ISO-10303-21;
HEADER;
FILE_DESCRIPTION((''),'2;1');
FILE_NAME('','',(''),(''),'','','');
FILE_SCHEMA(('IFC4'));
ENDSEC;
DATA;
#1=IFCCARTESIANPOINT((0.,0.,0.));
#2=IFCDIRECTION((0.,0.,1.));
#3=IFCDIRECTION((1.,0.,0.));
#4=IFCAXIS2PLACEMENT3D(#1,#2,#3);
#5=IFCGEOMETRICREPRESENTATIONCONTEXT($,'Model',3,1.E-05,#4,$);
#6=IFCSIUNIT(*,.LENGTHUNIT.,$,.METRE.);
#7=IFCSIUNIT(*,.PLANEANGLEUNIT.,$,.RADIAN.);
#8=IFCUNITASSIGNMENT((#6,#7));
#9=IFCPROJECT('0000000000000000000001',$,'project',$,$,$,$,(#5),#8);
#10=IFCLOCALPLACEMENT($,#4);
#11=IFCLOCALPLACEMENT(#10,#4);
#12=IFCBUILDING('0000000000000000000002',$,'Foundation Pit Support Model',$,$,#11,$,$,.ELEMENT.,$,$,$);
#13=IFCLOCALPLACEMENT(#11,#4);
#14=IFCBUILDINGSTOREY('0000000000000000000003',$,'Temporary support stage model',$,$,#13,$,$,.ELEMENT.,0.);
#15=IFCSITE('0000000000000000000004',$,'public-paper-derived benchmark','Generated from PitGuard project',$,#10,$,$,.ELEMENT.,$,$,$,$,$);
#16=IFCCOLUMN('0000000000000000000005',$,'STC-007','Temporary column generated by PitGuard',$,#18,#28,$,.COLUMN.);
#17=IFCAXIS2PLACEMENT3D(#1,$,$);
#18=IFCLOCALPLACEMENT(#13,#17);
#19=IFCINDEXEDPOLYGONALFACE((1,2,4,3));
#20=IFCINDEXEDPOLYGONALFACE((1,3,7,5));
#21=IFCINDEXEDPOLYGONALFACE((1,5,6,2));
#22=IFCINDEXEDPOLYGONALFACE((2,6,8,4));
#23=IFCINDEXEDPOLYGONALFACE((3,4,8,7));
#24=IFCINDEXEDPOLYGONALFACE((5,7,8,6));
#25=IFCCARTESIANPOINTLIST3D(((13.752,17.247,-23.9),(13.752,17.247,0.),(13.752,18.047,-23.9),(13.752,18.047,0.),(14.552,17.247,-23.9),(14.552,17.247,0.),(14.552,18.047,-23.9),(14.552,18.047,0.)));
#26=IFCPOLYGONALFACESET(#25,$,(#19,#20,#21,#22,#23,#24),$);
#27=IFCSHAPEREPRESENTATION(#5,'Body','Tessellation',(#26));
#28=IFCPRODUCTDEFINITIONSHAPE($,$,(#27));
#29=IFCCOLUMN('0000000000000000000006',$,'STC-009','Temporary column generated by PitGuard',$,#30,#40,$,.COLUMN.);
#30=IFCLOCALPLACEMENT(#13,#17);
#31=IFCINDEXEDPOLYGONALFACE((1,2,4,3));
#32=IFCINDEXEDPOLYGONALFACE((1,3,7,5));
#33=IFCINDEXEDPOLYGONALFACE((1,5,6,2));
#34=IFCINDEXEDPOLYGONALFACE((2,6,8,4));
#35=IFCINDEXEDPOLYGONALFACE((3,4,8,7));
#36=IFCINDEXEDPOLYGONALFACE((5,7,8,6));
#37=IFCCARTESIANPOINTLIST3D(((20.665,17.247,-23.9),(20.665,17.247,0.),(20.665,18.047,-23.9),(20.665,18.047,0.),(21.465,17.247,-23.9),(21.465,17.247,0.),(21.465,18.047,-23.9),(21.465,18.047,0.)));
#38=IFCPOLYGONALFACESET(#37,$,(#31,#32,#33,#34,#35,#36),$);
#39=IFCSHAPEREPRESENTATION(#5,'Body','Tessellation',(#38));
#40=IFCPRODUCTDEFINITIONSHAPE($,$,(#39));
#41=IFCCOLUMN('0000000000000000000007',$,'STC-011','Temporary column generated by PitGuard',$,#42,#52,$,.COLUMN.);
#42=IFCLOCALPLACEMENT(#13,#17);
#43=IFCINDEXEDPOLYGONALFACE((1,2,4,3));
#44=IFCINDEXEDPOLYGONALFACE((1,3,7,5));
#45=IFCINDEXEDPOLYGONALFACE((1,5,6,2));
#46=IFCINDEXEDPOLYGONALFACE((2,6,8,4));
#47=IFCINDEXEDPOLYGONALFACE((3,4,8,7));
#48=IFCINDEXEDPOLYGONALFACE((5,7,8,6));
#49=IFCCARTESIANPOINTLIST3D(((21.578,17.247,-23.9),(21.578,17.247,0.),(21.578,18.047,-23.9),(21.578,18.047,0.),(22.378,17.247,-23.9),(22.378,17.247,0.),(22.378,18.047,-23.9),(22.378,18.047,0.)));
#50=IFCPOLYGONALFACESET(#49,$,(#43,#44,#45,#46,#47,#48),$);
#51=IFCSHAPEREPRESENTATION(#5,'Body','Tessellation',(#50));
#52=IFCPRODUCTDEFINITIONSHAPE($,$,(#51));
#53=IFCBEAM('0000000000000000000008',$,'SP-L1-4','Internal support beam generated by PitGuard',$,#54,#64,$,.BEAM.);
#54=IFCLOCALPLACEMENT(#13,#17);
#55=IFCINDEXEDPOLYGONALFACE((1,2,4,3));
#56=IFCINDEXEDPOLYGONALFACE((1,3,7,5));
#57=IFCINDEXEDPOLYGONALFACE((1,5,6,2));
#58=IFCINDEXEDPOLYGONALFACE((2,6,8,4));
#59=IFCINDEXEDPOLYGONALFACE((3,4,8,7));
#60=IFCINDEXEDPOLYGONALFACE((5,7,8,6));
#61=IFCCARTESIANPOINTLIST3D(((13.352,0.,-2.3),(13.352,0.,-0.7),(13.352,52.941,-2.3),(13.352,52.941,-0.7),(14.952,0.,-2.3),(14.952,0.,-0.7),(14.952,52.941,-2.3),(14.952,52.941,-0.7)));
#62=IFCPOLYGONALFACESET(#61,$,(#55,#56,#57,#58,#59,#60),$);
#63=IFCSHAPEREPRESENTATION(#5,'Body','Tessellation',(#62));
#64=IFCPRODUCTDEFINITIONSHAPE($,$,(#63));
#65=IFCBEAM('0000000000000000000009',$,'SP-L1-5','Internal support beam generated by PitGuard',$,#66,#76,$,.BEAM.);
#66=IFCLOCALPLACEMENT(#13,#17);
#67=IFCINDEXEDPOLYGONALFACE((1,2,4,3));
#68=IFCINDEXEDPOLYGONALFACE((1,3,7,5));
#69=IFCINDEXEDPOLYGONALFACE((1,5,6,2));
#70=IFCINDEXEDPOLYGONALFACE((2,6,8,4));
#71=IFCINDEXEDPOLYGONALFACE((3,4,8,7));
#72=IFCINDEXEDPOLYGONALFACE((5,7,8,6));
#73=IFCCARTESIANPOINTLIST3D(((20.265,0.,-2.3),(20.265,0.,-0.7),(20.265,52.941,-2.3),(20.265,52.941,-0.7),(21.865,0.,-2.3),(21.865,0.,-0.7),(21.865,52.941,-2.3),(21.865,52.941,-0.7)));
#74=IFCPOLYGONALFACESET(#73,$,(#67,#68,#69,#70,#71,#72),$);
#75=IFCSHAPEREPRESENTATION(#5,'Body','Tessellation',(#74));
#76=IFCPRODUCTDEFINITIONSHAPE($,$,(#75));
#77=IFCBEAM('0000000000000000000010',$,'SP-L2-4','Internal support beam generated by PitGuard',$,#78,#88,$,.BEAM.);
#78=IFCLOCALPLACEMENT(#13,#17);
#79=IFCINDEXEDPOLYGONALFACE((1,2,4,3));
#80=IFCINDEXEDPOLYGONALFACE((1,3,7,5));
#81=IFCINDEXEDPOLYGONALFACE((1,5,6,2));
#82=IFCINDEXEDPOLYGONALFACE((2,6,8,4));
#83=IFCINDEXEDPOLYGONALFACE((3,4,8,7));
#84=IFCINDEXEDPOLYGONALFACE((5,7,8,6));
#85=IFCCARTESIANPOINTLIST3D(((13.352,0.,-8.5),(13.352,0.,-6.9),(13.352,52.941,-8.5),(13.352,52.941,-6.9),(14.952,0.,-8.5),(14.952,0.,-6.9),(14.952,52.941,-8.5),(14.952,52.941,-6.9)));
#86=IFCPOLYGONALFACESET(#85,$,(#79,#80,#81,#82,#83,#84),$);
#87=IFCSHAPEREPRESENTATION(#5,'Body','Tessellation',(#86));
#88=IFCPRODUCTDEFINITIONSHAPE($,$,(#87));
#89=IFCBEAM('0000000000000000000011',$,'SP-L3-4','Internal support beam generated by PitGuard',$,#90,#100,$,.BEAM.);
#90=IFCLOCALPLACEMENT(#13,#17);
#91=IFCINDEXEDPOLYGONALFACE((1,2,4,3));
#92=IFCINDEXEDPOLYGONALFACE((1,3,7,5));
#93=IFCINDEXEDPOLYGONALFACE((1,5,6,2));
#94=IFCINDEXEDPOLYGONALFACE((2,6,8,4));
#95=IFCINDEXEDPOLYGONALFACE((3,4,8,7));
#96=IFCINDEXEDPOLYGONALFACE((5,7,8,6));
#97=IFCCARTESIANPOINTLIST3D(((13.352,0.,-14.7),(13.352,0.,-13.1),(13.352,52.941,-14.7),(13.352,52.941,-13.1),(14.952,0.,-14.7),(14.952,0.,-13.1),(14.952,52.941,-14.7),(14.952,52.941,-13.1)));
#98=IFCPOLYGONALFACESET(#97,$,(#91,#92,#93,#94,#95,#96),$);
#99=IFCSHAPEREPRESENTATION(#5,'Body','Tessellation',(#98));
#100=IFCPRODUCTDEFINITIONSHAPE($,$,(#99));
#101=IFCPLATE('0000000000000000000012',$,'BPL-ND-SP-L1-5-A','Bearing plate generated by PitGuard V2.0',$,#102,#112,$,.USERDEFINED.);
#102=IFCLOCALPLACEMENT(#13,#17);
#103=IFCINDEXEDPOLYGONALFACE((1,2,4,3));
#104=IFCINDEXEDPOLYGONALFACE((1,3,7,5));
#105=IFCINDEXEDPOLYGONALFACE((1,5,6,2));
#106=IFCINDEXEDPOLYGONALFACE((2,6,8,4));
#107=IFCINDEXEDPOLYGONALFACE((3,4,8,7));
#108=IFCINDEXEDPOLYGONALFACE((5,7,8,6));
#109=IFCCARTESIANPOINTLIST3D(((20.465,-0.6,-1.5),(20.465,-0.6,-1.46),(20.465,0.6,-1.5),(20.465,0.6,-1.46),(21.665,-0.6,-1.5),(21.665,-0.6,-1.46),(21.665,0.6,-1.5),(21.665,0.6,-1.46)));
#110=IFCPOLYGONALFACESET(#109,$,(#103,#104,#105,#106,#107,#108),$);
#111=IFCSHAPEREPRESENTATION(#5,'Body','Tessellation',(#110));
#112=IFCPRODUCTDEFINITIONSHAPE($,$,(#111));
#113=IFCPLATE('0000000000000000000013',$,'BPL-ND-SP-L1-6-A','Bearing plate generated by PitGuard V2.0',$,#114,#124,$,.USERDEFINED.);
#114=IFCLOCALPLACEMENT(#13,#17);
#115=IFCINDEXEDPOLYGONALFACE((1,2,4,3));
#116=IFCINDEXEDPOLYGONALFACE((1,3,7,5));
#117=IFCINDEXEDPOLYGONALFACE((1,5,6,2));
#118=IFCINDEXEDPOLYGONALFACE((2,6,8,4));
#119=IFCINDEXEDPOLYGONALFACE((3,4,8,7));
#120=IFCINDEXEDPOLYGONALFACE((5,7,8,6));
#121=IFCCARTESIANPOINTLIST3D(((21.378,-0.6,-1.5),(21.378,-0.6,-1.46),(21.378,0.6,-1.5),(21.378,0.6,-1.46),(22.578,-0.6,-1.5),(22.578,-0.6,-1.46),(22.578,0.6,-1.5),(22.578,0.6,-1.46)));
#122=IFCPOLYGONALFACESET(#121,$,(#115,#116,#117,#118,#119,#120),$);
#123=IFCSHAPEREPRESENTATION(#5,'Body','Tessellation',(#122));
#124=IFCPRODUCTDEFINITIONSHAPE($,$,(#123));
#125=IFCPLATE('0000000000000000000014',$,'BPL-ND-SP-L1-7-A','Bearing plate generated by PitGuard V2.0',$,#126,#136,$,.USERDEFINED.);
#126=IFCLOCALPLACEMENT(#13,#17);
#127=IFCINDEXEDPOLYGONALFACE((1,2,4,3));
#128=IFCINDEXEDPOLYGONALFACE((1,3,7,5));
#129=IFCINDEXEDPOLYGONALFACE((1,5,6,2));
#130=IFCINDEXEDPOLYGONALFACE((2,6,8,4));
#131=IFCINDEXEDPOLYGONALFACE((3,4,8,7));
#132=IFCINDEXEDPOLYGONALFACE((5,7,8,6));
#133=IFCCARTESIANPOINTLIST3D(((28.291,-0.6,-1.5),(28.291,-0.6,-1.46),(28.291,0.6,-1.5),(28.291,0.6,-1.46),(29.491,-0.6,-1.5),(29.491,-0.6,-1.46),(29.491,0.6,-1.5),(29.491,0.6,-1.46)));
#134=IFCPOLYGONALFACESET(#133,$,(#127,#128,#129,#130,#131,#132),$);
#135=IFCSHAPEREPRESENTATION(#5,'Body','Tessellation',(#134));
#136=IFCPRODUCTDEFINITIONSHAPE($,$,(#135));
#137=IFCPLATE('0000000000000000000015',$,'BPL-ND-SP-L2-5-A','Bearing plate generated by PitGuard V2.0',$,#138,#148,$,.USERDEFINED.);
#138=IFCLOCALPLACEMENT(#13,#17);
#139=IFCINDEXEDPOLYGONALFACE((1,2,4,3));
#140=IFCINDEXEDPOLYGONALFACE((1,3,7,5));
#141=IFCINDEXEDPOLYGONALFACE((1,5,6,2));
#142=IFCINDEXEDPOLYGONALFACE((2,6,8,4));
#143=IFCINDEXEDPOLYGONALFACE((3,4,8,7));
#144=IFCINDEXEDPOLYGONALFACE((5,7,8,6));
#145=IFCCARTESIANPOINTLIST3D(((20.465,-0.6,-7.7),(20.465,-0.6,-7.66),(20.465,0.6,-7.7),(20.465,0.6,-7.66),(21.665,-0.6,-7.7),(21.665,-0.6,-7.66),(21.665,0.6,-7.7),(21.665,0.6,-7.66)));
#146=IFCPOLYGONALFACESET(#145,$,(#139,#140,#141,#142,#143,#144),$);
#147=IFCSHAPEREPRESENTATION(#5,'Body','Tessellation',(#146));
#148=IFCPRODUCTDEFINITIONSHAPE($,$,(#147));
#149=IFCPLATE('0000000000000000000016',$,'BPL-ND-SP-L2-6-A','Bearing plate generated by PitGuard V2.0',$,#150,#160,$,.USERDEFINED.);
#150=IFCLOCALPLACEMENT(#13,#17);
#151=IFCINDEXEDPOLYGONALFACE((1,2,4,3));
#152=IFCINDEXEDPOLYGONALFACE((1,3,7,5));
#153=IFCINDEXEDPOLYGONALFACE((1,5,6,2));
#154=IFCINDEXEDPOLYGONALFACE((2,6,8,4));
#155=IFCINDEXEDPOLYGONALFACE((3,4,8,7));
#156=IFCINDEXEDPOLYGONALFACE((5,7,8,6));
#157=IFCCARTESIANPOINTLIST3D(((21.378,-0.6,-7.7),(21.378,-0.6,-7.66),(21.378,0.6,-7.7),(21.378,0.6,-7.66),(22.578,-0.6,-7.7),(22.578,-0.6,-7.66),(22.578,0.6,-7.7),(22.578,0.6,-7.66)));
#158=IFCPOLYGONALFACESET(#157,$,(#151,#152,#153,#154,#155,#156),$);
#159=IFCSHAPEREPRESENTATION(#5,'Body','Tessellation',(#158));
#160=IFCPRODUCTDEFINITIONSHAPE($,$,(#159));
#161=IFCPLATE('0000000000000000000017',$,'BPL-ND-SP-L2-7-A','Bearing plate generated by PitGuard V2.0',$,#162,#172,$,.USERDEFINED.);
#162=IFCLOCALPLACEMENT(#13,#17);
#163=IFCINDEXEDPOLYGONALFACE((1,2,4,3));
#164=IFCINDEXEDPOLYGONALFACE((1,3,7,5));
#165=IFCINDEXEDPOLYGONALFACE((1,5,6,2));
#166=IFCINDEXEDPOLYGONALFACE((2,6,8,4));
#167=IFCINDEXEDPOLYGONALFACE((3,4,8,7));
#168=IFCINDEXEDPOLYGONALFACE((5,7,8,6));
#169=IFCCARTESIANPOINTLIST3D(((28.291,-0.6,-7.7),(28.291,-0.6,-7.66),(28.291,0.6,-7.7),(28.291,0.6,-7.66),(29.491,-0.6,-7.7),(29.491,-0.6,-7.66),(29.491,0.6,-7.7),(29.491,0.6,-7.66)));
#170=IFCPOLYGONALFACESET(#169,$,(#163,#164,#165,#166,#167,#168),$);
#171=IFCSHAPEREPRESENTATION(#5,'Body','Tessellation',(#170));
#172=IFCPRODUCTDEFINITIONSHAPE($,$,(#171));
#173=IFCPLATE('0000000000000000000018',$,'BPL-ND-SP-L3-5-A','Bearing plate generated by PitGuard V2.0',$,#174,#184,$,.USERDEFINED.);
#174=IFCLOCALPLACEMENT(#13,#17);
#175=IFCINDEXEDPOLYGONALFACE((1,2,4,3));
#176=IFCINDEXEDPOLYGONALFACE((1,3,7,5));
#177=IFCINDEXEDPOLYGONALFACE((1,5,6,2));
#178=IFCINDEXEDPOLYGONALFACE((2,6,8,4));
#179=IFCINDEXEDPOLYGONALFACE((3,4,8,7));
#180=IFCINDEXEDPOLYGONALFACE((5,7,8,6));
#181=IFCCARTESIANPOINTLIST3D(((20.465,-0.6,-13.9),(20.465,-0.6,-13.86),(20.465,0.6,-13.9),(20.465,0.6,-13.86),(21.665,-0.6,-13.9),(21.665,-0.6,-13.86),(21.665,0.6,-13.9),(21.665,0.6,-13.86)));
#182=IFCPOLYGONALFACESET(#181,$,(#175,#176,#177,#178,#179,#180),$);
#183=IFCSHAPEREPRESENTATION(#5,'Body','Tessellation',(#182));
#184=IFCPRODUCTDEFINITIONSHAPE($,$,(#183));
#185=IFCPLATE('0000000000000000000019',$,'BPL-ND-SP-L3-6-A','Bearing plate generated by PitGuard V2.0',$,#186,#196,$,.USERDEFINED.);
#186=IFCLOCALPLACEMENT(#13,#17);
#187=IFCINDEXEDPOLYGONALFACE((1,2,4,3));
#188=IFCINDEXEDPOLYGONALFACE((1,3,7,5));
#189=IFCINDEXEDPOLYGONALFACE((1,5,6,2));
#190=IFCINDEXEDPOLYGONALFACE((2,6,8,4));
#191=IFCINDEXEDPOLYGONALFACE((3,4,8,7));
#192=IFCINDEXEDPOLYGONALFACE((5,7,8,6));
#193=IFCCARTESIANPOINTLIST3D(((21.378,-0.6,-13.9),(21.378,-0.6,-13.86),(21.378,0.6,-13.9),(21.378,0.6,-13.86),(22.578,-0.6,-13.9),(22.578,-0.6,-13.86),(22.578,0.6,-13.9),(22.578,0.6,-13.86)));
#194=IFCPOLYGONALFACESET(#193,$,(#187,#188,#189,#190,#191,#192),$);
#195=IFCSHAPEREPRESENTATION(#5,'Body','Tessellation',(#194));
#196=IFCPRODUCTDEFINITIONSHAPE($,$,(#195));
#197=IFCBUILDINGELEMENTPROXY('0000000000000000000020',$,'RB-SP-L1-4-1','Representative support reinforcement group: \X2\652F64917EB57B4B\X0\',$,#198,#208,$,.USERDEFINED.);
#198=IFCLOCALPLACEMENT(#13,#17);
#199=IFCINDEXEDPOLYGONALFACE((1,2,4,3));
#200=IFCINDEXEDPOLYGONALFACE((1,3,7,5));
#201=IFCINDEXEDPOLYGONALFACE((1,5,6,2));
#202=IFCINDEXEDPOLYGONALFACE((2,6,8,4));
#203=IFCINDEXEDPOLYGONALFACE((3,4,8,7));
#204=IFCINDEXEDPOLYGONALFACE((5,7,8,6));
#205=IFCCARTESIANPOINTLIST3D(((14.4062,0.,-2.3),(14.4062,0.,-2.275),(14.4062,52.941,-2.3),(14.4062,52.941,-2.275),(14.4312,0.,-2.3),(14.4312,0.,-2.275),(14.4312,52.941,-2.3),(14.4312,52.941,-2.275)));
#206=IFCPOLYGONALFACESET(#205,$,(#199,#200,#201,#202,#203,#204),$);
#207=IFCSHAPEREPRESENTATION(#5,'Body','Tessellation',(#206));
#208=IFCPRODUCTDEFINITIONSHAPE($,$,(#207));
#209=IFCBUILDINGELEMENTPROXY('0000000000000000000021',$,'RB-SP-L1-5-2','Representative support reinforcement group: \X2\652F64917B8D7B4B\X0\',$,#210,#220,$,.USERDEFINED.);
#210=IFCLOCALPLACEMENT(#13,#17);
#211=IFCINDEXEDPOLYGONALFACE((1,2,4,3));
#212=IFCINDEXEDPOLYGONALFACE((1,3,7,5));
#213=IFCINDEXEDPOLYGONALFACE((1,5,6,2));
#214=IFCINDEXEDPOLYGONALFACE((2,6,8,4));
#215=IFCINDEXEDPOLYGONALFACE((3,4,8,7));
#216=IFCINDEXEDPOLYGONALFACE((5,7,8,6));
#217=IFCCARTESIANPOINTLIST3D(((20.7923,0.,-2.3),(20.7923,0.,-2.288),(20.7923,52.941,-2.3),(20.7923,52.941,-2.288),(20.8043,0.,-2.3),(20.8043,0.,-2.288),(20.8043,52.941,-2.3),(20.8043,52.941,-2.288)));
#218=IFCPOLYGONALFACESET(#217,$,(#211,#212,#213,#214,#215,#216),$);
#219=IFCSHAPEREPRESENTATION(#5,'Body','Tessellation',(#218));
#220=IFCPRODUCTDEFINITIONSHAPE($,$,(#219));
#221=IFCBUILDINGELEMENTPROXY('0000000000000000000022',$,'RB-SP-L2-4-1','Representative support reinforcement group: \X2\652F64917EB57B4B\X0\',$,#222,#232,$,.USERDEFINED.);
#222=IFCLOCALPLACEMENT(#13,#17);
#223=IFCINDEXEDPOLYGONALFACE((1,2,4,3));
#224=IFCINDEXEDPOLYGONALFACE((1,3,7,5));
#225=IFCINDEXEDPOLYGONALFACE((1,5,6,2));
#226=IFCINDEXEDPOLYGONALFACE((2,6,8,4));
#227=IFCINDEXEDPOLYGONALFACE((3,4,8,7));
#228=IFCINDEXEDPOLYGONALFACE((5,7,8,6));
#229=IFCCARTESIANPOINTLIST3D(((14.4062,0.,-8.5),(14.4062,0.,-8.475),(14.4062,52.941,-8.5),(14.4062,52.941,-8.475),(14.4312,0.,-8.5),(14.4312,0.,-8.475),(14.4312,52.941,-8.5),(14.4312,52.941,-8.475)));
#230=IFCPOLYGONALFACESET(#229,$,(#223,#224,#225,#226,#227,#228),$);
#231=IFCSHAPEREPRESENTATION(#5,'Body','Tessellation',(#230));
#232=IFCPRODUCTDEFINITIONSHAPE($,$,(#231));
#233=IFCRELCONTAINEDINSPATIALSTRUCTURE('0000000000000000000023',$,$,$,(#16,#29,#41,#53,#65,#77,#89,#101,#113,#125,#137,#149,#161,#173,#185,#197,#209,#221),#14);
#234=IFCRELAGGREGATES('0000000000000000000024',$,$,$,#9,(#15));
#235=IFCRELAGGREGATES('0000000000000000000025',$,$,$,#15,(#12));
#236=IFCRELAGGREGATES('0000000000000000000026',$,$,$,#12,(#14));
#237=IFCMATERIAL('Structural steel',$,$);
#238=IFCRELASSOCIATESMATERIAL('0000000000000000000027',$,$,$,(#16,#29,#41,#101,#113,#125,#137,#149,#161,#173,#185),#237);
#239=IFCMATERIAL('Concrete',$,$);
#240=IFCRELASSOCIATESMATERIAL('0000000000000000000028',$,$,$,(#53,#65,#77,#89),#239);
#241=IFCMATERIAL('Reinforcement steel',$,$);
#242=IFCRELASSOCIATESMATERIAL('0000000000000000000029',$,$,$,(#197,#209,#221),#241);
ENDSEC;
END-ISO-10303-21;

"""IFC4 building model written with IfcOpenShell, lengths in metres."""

from ifc_helpers import new_model, si_unit, frame, origin_with_axes, origin_2d, place, context, project, spatial, rectangle, extrude, material, element, save


model = new_model("IFC4")

# Units and contexts
model_context = context("Model", 3, precision=1e-05, world=origin_with_axes())
ifc_project = project(units=[si_unit("LENGTHUNIT", "METRE"), si_unit("PLANEANGLEUNIT", "RADIAN")], contexts=[model_context])

# Site, building, storey
site_placement = place(None, origin_with_axes())
site = spatial("IfcSite", under=ifc_project, at=site_placement, Name="public-paper-derived benchmark", Description="Generated from PitGuard project", CompositionType="ELEMENT")
building_placement = place(site_placement, origin_with_axes())
building = spatial("IfcBuilding", under=site, at=building_placement, Name="Foundation Pit Support Model", CompositionType="ELEMENT")
storey_placement = place(building_placement, origin_with_axes())
storey = spatial("IfcBuildingStorey", under=building, at=storey_placement, Name="Temporary support stage model", CompositionType="ELEMENT", Elevation=0.0)

# Columns
ifc_material_1 = material(Name="Structural steel")
for number, where, z_axis, x_axis, name in (
    (1, (14.152, 17.647, -23.9), (0.0, 0.0, 1.0), (1.0, 0.0, 0.0), "STC-007"),
    (2, (21.065, 17.647, -23.9), (0.0, 0.0, 1.0), (1.0, 0.0, 0.0), "STC-009"),
    (3, (21.978, 17.647, -23.9), (0.0, 0.0, 1.0), (1.0, 0.0, 0.0), "STC-011"),
):
    element("IfcColumn", number, at=place(storey_placement, frame(where, z_axis=z_axis, x_axis=x_axis)), inside=storey, material=ifc_material_1, Name=name, Description="Temporary column generated by PitGuard", PredefinedType="COLUMN", context=model_context, shape_type="SweptSolid", body=[
        extrude(rectangle(XDim=0.8, YDim=0.8, at=origin_2d()), origin_with_axes(), (0.0, 0.0, 1.0), 23.9),
    ])

# Beams
ifc_material_2 = material(Name="Concrete")
for number, where, z_axis, x_axis, name in (
    (4, (14.152, 26.4705, -2.3), (0.0, 0.0, 1.0), (0.0, 1.0, 0.0), "SP-L1-4"),
    (5, (21.065, 26.4705, -2.3), (0.0, 0.0, 1.0), (0.0, 1.0, 0.0), "SP-L1-5"),
    (6, (14.152, 26.4705, -8.5), (0.0, 0.0, 1.0), (0.0, 1.0, 0.0), "SP-L2-4"),
    (7, (14.152, 26.4705, -14.7), (0.0, 0.0, 1.0), (0.0, 1.0, 0.0), "SP-L3-4"),
):
    element("IfcBeam", number, at=place(storey_placement, frame(where, z_axis=z_axis, x_axis=x_axis)), inside=storey, material=ifc_material_2, Name=name, Description="Internal support beam generated by PitGuard", PredefinedType="BEAM", context=model_context, shape_type="SweptSolid", body=[
        extrude(rectangle(XDim=52.941, YDim=1.6, at=origin_2d()), origin_with_axes(), (0.0, 0.0, 1.0), 1.6),
    ])

# Plates
for number, where, z_axis, x_axis, name in (
    (8, (21.065, 0.0, -1.5), (0.0, 0.0, 1.0), (1.0, 0.0, 0.0), "BPL-ND-SP-L1-5-A"),
    (9, (21.978, 0.0, -1.5), (0.0, 0.0, 1.0), (1.0, 0.0, 0.0), "BPL-ND-SP-L1-6-A"),
    (10, (28.891, 0.0, -1.5), (0.0, 0.0, 1.0), (1.0, 0.0, 0.0), "BPL-ND-SP-L1-7-A"),
    (11, (21.065, 0.0, -7.7), (0.0, 0.0, 1.0), (1.0, 0.0, 0.0), "BPL-ND-SP-L2-5-A"),
    (12, (21.978, 0.0, -7.7), (0.0, 0.0, 1.0), (1.0, 0.0, 0.0), "BPL-ND-SP-L2-6-A"),
    (13, (28.891, 0.0, -7.7), (0.0, 0.0, 1.0), (1.0, 0.0, 0.0), "BPL-ND-SP-L2-7-A"),
    (14, (21.065, 0.0, -13.9), (0.0, 0.0, 1.0), (1.0, 0.0, 0.0), "BPL-ND-SP-L3-5-A"),
    (15, (21.978, 0.0, -13.9), (0.0, 0.0, 1.0), (1.0, 0.0, 0.0), "BPL-ND-SP-L3-6-A"),
):
    element("IfcPlate", number, at=place(storey_placement, frame(where, z_axis=z_axis, x_axis=x_axis)), inside=storey, material=ifc_material_1, Name=name, Description="Bearing plate generated by PitGuard V2.0", PredefinedType="USERDEFINED", context=model_context, shape_type="SweptSolid", body=[
        extrude(rectangle(XDim=1.2, YDim=1.2, at=origin_2d()), origin_with_axes(), (0.0, 0.0, 1.0), 0.04),
    ])

# Building element proxies
ifc_material_3 = material(Name="Reinforcement steel")
proxy_1_placement = place(storey_placement, frame((14.4187, 26.4705, -2.3), z_axis=(0.0, 0.0, 1.0), x_axis=(0.0, 1.0, 0.0)))
element("IfcBuildingElementProxy", 16, at=proxy_1_placement, inside=storey, material=ifc_material_3, Name="RB-SP-L1-4-1", Description="Representative support reinforcement group: 支撑纵筋", PredefinedType="USERDEFINED", context=model_context, shape_type="SweptSolid", body=[
    extrude(rectangle(XDim=52.941, YDim=0.025, at=origin_2d()), origin_with_axes(), (0.0, 0.0, 1.0), 0.025),
])
proxy_2_placement = place(storey_placement, frame((20.7983, 26.4705, -2.3), z_axis=(0.0, 0.0, 1.0), x_axis=(0.0, 1.0, 0.0)))
element("IfcBuildingElementProxy", 17, at=proxy_2_placement, inside=storey, material=ifc_material_3, Name="RB-SP-L1-5-2", Description="Representative support reinforcement group: 支撑箍筋", PredefinedType="USERDEFINED", context=model_context, shape_type="SweptSolid", body=[
    extrude(rectangle(XDim=52.941, YDim=0.012, at=origin_2d()), origin_with_axes(), (0.0, 0.0, 1.0), 0.012),
])
proxy_3_placement = place(storey_placement, frame((14.4187, 26.4705, -8.5), z_axis=(0.0, 0.0, 1.0), x_axis=(0.0, 1.0, 0.0)))
element("IfcBuildingElementProxy", 18, at=proxy_3_placement, inside=storey, material=ifc_material_3, Name="RB-SP-L2-4-1", Description="Representative support reinforcement group: 支撑纵筋", PredefinedType="USERDEFINED", context=model_context, shape_type="SweptSolid", body=[
    extrude(rectangle(XDim=52.941, YDim=0.025, at=origin_2d()), origin_with_axes(), (0.0, 0.0, 1.0), 0.025),
])

save(model, "model.ifc")
